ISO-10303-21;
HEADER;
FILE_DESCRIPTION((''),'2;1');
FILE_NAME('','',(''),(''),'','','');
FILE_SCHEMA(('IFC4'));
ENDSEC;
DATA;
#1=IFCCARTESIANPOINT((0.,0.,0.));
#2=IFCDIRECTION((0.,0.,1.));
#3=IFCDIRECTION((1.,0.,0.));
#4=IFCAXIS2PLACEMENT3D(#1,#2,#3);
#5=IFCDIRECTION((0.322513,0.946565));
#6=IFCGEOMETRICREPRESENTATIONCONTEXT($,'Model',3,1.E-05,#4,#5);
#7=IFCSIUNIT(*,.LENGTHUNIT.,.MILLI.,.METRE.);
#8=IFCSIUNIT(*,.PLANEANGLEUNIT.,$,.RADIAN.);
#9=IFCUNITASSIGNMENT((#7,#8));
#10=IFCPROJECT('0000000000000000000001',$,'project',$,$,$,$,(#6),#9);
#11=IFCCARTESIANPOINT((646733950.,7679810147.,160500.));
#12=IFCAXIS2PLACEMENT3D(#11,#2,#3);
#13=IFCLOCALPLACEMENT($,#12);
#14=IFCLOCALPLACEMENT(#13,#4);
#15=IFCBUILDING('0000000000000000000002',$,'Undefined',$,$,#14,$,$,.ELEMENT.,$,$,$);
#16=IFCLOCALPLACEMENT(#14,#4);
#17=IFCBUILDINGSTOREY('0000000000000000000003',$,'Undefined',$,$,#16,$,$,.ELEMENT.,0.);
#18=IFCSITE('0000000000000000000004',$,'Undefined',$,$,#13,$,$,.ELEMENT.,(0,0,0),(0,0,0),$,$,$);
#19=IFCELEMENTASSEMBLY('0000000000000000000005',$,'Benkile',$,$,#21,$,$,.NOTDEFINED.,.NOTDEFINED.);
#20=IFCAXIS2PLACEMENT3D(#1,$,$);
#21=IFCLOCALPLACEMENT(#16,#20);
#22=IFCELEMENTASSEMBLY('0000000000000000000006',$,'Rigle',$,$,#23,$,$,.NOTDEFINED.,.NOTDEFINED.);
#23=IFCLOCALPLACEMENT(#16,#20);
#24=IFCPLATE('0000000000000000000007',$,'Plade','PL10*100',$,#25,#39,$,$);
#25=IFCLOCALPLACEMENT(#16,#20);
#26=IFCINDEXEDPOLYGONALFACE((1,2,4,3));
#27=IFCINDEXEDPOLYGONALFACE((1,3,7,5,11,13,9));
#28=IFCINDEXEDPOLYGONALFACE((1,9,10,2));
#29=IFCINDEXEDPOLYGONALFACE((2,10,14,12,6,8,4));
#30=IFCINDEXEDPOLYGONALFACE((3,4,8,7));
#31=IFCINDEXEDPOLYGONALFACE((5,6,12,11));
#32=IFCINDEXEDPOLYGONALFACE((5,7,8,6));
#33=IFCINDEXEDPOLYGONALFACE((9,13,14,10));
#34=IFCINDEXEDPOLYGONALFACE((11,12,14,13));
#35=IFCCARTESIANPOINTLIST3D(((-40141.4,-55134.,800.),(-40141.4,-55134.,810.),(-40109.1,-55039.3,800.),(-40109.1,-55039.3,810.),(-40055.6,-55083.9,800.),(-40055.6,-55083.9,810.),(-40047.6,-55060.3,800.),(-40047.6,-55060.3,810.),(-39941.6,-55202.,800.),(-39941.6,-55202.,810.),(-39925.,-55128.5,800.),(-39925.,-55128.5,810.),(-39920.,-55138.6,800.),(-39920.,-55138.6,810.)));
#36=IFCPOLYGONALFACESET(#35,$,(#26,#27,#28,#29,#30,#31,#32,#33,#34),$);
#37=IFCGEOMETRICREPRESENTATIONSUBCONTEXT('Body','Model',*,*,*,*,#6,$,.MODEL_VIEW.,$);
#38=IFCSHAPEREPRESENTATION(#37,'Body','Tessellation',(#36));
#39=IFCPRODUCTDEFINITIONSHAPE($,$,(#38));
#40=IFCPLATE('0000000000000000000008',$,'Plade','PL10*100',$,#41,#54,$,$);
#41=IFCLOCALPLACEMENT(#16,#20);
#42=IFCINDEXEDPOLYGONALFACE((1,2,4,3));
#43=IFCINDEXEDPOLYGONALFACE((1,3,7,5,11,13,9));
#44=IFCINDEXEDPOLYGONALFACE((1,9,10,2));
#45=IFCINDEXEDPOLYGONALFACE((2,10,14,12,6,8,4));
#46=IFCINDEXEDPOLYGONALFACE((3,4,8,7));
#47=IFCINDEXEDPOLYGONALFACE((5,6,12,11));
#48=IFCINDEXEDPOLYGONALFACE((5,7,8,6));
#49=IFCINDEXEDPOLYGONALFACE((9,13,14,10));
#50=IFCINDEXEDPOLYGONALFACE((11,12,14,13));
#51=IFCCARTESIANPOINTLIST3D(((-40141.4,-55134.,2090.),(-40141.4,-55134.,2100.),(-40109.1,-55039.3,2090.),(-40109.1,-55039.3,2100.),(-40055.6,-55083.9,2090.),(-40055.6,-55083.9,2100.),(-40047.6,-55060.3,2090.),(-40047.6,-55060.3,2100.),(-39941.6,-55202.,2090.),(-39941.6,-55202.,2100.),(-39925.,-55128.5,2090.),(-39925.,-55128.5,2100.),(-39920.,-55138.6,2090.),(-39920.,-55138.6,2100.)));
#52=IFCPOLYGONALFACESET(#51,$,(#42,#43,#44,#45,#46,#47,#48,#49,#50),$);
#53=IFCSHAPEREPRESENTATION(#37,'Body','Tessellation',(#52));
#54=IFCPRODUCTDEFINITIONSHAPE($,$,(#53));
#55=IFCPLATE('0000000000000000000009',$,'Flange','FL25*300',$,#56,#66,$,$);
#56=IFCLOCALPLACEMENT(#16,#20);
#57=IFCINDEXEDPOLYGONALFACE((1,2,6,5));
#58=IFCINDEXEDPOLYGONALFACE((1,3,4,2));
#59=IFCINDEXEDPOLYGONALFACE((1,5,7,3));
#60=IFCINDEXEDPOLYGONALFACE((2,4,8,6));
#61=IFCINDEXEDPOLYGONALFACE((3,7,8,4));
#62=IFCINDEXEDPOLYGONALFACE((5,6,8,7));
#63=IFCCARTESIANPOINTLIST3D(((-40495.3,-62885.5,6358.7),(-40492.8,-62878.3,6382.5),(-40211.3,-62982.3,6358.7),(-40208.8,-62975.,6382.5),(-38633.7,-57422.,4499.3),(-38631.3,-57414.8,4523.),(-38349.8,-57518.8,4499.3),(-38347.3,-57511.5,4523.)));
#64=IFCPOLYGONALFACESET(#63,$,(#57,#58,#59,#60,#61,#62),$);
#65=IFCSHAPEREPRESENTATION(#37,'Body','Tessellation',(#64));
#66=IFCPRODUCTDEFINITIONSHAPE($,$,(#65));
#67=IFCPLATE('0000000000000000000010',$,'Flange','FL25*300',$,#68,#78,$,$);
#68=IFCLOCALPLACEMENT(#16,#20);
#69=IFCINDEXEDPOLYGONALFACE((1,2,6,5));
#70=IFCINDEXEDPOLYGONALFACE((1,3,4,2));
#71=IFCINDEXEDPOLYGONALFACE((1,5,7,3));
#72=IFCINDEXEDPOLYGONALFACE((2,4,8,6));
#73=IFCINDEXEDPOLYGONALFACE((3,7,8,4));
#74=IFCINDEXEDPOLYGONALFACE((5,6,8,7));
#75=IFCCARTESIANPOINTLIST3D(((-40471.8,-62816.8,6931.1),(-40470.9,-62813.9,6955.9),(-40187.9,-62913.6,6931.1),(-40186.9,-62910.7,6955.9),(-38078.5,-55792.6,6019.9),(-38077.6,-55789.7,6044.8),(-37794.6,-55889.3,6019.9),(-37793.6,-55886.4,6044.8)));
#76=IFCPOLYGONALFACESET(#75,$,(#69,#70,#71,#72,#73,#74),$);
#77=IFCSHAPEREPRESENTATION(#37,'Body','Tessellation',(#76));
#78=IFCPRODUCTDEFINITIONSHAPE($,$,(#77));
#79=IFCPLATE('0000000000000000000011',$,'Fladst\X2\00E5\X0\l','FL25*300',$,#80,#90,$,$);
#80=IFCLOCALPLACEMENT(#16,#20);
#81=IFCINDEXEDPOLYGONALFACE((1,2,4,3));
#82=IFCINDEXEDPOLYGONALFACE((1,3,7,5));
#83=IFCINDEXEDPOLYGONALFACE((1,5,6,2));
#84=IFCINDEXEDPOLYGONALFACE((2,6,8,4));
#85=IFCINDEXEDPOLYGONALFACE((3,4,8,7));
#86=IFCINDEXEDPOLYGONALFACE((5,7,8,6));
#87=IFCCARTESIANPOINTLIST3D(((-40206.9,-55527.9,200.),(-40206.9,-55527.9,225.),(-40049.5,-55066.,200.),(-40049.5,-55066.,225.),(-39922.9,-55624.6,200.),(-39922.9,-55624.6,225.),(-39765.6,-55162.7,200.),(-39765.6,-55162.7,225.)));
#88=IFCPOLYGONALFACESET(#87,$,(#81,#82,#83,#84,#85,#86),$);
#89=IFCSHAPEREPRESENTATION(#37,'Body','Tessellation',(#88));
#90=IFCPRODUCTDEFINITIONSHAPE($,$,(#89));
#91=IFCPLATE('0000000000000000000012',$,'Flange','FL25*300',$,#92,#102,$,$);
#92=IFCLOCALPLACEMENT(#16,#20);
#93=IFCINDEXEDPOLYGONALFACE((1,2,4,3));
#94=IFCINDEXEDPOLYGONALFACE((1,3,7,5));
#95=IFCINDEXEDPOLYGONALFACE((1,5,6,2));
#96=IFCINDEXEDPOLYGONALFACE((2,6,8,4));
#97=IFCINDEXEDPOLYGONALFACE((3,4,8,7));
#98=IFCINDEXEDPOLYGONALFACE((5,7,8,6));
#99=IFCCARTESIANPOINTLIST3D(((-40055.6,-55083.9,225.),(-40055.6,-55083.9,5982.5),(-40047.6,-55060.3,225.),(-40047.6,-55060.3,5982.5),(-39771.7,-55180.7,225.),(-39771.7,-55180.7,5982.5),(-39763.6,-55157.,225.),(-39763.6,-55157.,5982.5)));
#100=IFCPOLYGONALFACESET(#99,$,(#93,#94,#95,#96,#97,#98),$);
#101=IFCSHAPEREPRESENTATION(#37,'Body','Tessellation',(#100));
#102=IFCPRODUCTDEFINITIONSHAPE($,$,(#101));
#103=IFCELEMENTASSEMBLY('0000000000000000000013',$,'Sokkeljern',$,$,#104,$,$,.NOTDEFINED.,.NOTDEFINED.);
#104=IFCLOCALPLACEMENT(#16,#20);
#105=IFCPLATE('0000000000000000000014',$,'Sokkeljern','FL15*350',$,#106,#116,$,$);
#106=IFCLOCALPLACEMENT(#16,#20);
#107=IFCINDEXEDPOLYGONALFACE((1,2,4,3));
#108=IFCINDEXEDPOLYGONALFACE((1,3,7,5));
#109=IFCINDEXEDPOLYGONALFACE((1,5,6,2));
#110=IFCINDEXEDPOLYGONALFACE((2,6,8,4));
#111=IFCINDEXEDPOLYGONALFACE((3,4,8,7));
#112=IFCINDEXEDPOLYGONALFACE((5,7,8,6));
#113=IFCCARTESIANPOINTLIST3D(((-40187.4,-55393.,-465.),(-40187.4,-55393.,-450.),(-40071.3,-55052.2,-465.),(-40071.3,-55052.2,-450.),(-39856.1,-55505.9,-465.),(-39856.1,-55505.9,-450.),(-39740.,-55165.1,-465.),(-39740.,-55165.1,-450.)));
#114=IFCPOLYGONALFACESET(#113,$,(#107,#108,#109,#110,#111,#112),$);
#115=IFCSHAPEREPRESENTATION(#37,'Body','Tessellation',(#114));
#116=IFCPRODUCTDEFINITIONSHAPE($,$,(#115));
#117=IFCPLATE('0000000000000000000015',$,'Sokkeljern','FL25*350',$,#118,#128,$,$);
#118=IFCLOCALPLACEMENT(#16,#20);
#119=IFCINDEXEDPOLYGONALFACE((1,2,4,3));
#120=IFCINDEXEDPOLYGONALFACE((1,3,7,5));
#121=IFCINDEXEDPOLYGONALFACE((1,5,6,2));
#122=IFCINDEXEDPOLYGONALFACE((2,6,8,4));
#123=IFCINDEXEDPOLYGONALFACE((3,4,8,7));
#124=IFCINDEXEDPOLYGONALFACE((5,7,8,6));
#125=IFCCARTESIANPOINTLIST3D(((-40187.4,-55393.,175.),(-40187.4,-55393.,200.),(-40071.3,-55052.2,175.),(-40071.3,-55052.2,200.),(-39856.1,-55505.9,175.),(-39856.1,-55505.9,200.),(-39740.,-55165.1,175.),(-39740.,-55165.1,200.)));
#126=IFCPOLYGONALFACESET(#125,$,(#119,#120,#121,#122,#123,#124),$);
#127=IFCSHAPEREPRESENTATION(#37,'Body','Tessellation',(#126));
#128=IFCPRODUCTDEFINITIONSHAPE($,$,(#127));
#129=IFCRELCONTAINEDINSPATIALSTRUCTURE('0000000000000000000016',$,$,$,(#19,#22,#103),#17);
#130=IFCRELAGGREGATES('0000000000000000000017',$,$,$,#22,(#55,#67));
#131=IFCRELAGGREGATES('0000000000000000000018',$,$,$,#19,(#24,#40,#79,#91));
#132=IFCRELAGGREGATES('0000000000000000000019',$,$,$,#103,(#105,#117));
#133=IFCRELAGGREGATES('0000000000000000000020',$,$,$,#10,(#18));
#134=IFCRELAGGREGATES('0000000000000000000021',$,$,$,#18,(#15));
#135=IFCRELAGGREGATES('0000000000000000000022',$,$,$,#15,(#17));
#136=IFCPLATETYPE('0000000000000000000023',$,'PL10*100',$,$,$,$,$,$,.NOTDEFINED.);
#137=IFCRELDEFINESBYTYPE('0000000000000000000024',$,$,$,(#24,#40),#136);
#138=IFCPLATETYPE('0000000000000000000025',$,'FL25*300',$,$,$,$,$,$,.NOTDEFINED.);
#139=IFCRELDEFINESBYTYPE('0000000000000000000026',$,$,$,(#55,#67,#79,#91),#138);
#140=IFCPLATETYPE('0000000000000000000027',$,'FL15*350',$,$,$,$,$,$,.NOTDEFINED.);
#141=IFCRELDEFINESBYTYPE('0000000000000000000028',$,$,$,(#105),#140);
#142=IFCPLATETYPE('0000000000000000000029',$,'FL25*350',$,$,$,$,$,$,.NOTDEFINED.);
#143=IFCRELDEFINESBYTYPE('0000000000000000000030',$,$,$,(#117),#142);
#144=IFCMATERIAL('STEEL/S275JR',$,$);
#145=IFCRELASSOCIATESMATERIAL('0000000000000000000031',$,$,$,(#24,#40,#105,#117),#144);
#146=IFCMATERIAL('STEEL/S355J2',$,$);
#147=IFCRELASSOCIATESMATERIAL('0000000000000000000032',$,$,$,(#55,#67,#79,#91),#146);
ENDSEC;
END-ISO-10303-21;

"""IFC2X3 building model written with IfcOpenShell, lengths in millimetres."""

from ifc_helpers import new_model, si_unit, direction, frame, origin_with_axes, place, context, subcontext, project, spatial, polyline, outline, extrude, boolean, clip, halfspace, material, type_object, element, aggregate, save


model = new_model("IFC2X3")

# Units and contexts
model_context = context("Model", 3, precision=1e-05, world=origin_with_axes(), true_north=direction((0.322513, 0.946565)))
body_context = subcontext(model_context, "Body", "Model", "MODEL_VIEW")
ifc_project = project(units=[si_unit("LENGTHUNIT", "METRE", prefix="MILLI"), si_unit("PLANEANGLEUNIT", "RADIAN")], contexts=[model_context])

# Site, building, storey
site_placement = place(None, frame((646733950.0, 7679810147.0, 160500.0), z_axis=(0.0, 0.0, 1.0), x_axis=(1.0, 0.0, 0.0)))
site = spatial("IfcSite", under=ifc_project, at=site_placement, Name="Undefined", CompositionType="ELEMENT", RefLatitude=(0, 0, 0), RefLongitude=(0, 0, 0))
building_placement = place(site_placement, origin_with_axes())
building = spatial("IfcBuilding", under=site, at=building_placement, Name="Undefined", CompositionType="ELEMENT")
storey_placement = place(building_placement, origin_with_axes())
storey = spatial("IfcBuildingStorey", under=building, at=storey_placement, Name="Undefined", CompositionType="ELEMENT", Elevation=0.0)

# Element assembly
ifc_material_1 = material(Name="STEEL/S355J2")
assembly_1_placement = place(storey_placement, origin_with_axes())
assembly_1 = element("IfcElementAssembly", 1, at=assembly_1_placement, inside=storey, Name="Benkile", AssemblyPlace="NOTDEFINED", PredefinedType="NOTDEFINED")

# Shared definitions
ifc_material_2 = material(Name="STEEL/S275JR")

# Element assembly
assembly_2_placement = place(storey_placement, origin_with_axes())
assembly_2 = element("IfcElementAssembly", 2, at=assembly_2_placement, inside=storey, Name="Rigle", AssemblyPlace="NOTDEFINED", PredefinedType="NOTDEFINED")

# Plates
plate_type_1 = type_object("IfcPlateType", Name="PL10*100", PredefinedType="NOTDEFINED")
plate_1_placement = place(assembly_1_placement, frame((-39909.4, -55107.4, 805.0), z_axis=(0.0, 0.0, 1.0), x_axis=(-0.946565, 0.322513, 0.0)))
plate_1 = element("IfcPlate", 3, at=plate_1_placement, type_object=plate_type_1, material=ifc_material_2, Name="Plade", Description="PL10*100", context=body_context, shape_type="CSG", body=[
    boolean("DIFFERENCE", extrude(outline(polyline([(0.0, 25.0), (146.0, 25.0), (146.0, 0.0), (211.0, 0.0), (211.0, 100.0), (0.0, 100.0), (0.0, 25.0)])), frame((0.0, 0.0, -5.0), z_axis=(0.0, 0.0, 1.0), x_axis=(1.0, 0.0, 0.0)), (0.0, 0.0, 1.0), 10.0), extrude(outline(polyline([(0.0, 0.0), (8.0, 0.0), (0.0, 8.0), (0.0, 0.0)])), frame((0.0, 25.0, -7.5), z_axis=(0.0, 0.0, 1.0), x_axis=(1.0, 0.0, 0.0)), (0.0, 0.0, 1.0), 15.0)),
])
plate_2_placement = place(assembly_1_placement, frame((-39909.4, -55107.4, 2095.0), z_axis=(0.0, 0.0, 1.0), x_axis=(-0.946565, 0.322513, 0.0)))
plate_2 = element("IfcPlate", 4, at=plate_2_placement, type_object=plate_type_1, material=ifc_material_2, Name="Plade", Description="PL10*100", context=body_context, shape_type="CSG", body=[
    boolean("DIFFERENCE", extrude(outline(polyline([(0.0, 25.0), (146.0, 25.0), (146.0, 0.0), (211.0, 0.0), (211.0, 100.0), (0.0, 100.0), (0.0, 25.0)])), frame((0.0, 0.0, -5.0), z_axis=(0.0, 0.0, 1.0), x_axis=(1.0, 0.0, 0.0)), (0.0, 0.0, 1.0), 10.0), extrude(outline(polyline([(0.0, 0.0), (8.0, 0.0), (0.0, 8.0), (0.0, 0.0)])), frame((0.0, 25.0, -7.5), z_axis=(0.0, 0.0, 1.0), x_axis=(1.0, 0.0, 0.0)), (0.0, 0.0, 1.0), 15.0)),
])
plate_type_2 = type_object("IfcPlateType", Name="FL25*300", PredefinedType="NOTDEFINED")
plate_3_placement = place(assembly_2_placement, frame((-38490.5, -57466.8, 4511.2), z_axis=(-0.098895, -0.290253, -0.951826), x_axis=(-0.306976, -0.900965, 0.306638)))
plate_3 = element("IfcPlate", 5, at=plate_3_placement, type_object=plate_type_2, material=ifc_material_1, Name="Flange", Description="FL25*300", context=body_context, shape_type="Clipping", body=[
    clip(extrude(outline(polyline([(0.0, -150.0), (0.0, 150.0), (6064.1, 150.0), (6064.1, -150.0), (0.0, -150.0)])), frame((0.0, 0.0, -12.5), z_axis=(0.0, 0.0, 1.0), x_axis=(1.0, 0.0, 0.0)), (0.0, 0.0, 1.0), 25.0), halfspace(frame((6064.1, 0.0, 0.3), z_axis=(1.0, 0.0, 0.0), x_axis=(0.0, 1.0, 0.0)), False)),
])
plate_4_placement = place(assembly_2_placement, frame((-37936.1, -55839.5, 6032.4), z_axis=(-0.039304, -0.115357, -0.992546), x_axis=(-0.320109, -0.93951, 0.121869)))
plate_4 = element("IfcPlate", 6, at=plate_4_placement, type_object=plate_type_2, material=ifc_material_1, Name="Flange", Description="FL25*300", context=body_context, shape_type="Clipping", body=[
    clip(extrude(outline(polyline([(0.0, -150.0), (0.0, 150.0), (7476.5, 150.0), (7476.5, -150.0), (0.0, -150.0)])), frame((0.0, 0.0, -12.5), z_axis=(0.0, 0.0, 1.0), x_axis=(1.0, 0.0, 0.0)), (0.0, 0.0, 1.0), 25.0), halfspace(frame((7476.5, 0.0, 287.5), z_axis=(1.0, 0.0, 0.0), x_axis=(0.0, 1.0, 0.0)), False)),
])
aggregate(assembly_2, [plate_3, plate_4])
plate_5_placement = place(assembly_1_placement, frame((-39907.5, -55114.3, 212.5), z_axis=(0.0, 0.0, -1.0), x_axis=(-0.322513, -0.946565, 0.0)))
plate_5 = element("IfcPlate", 7, at=plate_5_placement, type_object=plate_type_2, material=ifc_material_1, Name="Fladstål", Description="FL25*300", context=body_context, shape_type="SweptSolid", body=[
    extrude(outline(polyline([(0.0, -150.0), (0.0, 150.0), (488.0, 150.0), (488.0, -150.0), (0.0, -150.0)])), frame((0.0, 0.0, -12.5), z_axis=(0.0, 0.0, 1.0), x_axis=(1.0, 0.0, 0.0)), (0.0, 0.0, 1.0), 25.0),
])
plate_6_placement = place(assembly_1_placement, frame((-39909.6, -55120.5, 200.0), z_axis=(-0.322513, -0.946565, 0.0), x_axis=(0.0, 0.0, 1.0)))
plate_6 = element("IfcPlate", 8, at=plate_6_placement, type_object=plate_type_2, material=ifc_material_1, Name="Flange", Description="FL25*300", context=body_context, shape_type="Clipping", body=[
    clip(extrude(outline(polyline([(25.0, -150.0), (25.0, 150.0), (5782.5, 150.0), (5782.5, -150.0), (25.0, -150.0)])), frame((0.0, 0.0, -12.5), z_axis=(0.0, 0.0, 1.0), x_axis=(1.0, 0.0, 0.0)), (0.0, 0.0, 1.0), 25.0), halfspace(frame((25.0, 0.0, 12.5), z_axis=(-1.0, 0.0, 0.0), x_axis=(0.0, 1.0, 0.0)), False)),
])
aggregate(assembly_1, [plate_1, plate_2, plate_5, plate_6])

# Element assembly, plates
assembly_3_placement = place(storey_placement, origin_with_axes())
assembly_3 = element("IfcElementAssembly", 9, at=assembly_3_placement, inside=storey, Name="Sokkeljern", AssemblyPlace="NOTDEFINED", PredefinedType="NOTDEFINED")
plate_type_3 = type_object("IfcPlateType", Name="FL15*350", PredefinedType="NOTDEFINED")
plate_7_placement = place(assembly_3_placement, frame((-39905.6, -55108.7, -457.5), z_axis=(0.0, 0.0, -1.0), x_axis=(-0.322513, -0.946565, 0.0)))
plate_7 = element("IfcPlate", 10, at=plate_7_placement, type_object=plate_type_3, material=ifc_material_2, Name="Sokkeljern", Description="FL15*350", context=body_context, shape_type="SweptSolid", body=[
    extrude(outline(polyline([(0.0, -175.0), (0.0, 175.0), (360.0, 175.0), (360.0, -175.0), (0.0, -175.0)])), frame((0.0, 0.0, -7.5), z_axis=(0.0, 0.0, 1.0), x_axis=(1.0, 0.0, 0.0)), (0.0, 0.0, 1.0), 15.0),
])
plate_type_4 = type_object("IfcPlateType", Name="FL25*350", PredefinedType="NOTDEFINED")
plate_8_placement = place(assembly_3_placement, frame((-39905.6, -55108.7, 187.5), z_axis=(0.0, 0.0, -1.0), x_axis=(-0.322513, -0.946565, 0.0)))
plate_8 = element("IfcPlate", 11, at=plate_8_placement, type_object=plate_type_4, material=ifc_material_2, Name="Sokkeljern", Description="FL25*350", context=body_context, shape_type="SweptSolid", body=[
    extrude(outline(polyline([(0.0, -175.0), (0.0, 175.0), (360.0, 175.0), (360.0, -175.0), (0.0, -175.0)])), frame((0.0, 0.0, -12.5), z_axis=(0.0, 0.0, 1.0), x_axis=(1.0, 0.0, 0.0)), (0.0, 0.0, 1.0), 25.0),
])
aggregate(assembly_3, [plate_7, plate_8])

save(model, "model.ifc")
